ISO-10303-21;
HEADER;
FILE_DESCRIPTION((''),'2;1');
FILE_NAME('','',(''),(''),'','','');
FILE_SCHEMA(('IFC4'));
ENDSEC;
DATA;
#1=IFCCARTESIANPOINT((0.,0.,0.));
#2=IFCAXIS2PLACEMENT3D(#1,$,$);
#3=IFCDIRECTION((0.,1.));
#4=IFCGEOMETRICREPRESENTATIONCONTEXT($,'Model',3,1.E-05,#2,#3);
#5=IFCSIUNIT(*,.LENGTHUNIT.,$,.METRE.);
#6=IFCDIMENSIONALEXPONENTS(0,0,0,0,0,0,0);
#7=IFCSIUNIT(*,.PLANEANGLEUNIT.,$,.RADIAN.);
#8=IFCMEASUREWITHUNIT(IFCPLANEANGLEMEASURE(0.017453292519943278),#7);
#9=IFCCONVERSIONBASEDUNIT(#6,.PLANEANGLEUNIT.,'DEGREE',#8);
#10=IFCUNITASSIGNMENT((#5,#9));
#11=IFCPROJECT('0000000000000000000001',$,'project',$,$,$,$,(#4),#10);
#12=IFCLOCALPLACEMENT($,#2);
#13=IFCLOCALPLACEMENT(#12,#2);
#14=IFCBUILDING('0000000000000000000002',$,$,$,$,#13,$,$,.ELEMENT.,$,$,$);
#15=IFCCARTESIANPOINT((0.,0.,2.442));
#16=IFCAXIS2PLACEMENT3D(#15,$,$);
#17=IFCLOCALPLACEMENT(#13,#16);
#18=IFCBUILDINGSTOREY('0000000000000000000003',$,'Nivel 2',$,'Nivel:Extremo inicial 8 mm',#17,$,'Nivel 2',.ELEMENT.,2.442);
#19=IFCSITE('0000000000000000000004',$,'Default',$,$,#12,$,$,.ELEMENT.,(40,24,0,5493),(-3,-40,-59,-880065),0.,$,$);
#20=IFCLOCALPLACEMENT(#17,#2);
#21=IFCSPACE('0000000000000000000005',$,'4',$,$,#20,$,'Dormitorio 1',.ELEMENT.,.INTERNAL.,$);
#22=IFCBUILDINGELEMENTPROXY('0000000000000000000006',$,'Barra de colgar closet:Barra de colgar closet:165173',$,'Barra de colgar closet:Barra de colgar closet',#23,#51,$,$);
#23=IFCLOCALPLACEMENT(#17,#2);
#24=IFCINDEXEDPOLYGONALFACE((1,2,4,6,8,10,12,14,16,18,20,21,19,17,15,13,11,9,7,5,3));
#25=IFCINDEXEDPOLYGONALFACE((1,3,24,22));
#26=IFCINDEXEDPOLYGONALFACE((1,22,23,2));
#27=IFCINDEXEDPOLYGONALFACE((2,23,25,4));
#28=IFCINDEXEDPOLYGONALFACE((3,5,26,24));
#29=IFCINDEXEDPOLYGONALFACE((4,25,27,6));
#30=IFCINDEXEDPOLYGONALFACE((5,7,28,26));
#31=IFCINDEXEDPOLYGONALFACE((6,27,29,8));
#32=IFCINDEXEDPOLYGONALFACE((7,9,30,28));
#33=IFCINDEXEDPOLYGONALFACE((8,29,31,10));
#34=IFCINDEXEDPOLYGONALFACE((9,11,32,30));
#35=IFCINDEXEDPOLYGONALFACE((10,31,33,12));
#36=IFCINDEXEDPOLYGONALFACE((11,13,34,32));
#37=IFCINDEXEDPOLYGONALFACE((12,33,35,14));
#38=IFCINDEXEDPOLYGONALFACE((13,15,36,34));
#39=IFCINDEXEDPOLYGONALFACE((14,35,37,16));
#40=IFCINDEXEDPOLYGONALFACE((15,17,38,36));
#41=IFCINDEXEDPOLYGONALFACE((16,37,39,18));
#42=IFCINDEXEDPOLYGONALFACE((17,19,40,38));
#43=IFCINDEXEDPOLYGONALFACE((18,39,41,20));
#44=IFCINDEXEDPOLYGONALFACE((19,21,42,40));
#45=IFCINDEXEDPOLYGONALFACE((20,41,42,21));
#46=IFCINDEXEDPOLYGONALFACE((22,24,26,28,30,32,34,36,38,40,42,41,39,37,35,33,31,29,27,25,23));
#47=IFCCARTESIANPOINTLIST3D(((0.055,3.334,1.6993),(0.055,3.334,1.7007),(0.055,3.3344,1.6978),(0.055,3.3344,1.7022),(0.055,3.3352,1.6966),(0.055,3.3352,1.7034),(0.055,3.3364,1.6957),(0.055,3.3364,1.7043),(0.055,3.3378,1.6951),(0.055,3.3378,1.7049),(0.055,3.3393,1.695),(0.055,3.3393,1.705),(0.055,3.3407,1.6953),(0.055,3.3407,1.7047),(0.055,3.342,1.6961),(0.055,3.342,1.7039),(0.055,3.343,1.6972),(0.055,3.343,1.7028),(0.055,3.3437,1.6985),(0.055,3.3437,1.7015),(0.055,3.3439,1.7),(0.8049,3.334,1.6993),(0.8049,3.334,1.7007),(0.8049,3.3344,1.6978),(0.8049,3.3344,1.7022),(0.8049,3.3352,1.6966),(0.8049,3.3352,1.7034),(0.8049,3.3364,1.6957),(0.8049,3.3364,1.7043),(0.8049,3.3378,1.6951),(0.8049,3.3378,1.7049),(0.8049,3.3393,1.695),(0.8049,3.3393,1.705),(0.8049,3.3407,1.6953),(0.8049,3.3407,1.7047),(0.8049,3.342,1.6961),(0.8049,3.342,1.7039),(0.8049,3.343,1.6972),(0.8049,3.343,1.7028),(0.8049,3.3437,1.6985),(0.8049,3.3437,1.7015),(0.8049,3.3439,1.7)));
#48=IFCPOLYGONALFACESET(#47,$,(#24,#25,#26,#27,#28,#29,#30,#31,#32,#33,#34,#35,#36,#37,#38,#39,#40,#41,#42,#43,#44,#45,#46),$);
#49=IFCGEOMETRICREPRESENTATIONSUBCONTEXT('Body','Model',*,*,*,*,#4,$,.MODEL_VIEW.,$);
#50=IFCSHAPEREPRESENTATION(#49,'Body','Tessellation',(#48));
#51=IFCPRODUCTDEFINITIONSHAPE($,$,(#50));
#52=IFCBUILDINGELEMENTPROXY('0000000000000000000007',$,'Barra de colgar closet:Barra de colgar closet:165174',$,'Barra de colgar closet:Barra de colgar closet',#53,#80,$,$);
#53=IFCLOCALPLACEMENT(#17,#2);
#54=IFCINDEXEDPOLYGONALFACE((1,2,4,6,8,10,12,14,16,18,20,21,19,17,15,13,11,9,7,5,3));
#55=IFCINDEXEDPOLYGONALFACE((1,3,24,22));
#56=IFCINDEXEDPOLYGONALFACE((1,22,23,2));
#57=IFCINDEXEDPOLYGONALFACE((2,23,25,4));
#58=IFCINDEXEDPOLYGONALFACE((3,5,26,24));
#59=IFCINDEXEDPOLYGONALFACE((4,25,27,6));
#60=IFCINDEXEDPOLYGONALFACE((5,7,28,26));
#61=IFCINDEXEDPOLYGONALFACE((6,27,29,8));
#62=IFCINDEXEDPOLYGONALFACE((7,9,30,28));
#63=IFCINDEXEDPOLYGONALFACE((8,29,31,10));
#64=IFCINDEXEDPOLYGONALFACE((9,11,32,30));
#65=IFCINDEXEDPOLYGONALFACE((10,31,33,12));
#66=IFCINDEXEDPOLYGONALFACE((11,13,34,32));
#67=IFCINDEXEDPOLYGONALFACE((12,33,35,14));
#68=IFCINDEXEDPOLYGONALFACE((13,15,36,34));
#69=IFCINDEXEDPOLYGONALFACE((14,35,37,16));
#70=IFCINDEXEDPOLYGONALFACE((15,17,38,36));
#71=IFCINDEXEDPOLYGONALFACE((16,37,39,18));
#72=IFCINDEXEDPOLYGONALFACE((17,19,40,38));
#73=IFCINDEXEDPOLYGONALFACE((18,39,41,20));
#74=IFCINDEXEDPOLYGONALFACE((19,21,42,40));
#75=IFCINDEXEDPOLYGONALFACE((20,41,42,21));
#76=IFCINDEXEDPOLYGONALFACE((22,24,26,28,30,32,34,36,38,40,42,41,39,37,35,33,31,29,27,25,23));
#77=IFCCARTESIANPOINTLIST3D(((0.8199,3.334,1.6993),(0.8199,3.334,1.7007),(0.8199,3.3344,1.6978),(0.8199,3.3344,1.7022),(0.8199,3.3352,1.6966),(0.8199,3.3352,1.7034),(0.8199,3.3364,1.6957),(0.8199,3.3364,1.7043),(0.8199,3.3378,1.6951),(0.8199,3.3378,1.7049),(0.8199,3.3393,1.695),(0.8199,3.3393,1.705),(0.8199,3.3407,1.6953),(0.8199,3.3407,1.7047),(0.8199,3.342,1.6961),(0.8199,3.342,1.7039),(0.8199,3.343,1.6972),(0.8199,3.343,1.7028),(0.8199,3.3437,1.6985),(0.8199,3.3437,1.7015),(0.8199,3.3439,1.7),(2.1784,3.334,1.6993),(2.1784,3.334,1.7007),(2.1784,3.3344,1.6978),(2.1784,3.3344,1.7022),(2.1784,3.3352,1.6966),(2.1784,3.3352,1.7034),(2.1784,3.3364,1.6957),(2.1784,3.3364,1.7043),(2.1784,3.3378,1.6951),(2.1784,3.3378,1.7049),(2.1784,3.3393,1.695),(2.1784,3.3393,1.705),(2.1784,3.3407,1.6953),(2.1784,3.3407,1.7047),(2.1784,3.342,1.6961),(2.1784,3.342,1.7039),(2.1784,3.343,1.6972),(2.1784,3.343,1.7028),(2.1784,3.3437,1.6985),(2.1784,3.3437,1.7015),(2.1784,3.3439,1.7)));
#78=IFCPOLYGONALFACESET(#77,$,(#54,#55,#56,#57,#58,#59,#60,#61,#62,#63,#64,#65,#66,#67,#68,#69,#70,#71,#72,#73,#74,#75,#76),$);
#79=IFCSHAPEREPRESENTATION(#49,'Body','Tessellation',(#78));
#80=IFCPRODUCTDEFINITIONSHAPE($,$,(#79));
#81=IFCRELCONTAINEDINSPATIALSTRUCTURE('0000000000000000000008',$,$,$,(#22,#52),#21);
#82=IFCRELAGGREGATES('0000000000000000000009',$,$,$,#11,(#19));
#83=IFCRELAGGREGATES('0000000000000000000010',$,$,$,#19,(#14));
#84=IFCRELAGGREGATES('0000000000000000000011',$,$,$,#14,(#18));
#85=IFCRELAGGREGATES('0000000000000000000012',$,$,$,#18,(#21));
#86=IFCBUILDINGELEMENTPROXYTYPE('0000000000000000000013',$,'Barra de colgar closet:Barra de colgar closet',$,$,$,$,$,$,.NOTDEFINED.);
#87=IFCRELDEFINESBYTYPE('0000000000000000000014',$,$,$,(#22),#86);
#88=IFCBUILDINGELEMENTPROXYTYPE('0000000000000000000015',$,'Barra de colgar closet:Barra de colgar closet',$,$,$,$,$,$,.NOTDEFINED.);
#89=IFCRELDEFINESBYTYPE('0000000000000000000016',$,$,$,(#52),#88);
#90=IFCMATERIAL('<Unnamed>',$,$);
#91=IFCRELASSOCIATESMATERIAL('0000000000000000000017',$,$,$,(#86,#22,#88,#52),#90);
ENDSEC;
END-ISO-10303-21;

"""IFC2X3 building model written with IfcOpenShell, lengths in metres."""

from ifc_helpers import new_model, entity, si_unit, converted_unit, direction, frame, frame_2d, origin, place, context, subcontext, project, spatial, circle, extrude, source, transform, mapped, material, type_object, type_shapes, element, save


model = new_model("IFC2X3")

# Units and contexts
model_context = context("Model", 3, precision=1e-05, world=origin(), true_north=direction((0.0, 1.0)))
body_context = subcontext(model_context, "Body", "Model", "MODEL_VIEW")
ifc_project = project(units=[si_unit("LENGTHUNIT", "METRE"), converted_unit("PLANEANGLEUNIT", "DEGREE", entity("IfcPlaneAngleMeasure", 0.017453292519943278), si_unit("PLANEANGLEUNIT", "RADIAN"), dimensions=[0, 0, 0, 0, 0, 0, 0])], contexts=[model_context])

# Site, building, storey
site_placement = place(None, origin())
site = spatial("IfcSite", under=ifc_project, at=site_placement, Name="Default", CompositionType="ELEMENT", RefLatitude=(40, 24, 0, 5493), RefLongitude=(-3, -40, -59, -880065), RefElevation=0.0)
building_placement = place(site_placement, origin())
building = spatial("IfcBuilding", under=site, at=building_placement, CompositionType="ELEMENT")
storey_placement = place(building_placement, frame((0.0, 0.0, 2.442)))
storey = spatial("IfcBuildingStorey", under=building, at=storey_placement, Name="Nivel 2", ObjectType="Nivel:Extremo inicial 8 mm", LongName="Nivel 2", CompositionType="ELEMENT", Elevation=2.442)

# Shared definitions
ifc_material_1 = material(Name="<Unnamed>")

# Shared definitions
space_1_placement = place(storey_placement, origin())
space_1 = spatial("IfcSpace", under=storey, at=space_1_placement, Name="4", LongName="Dormitorio 1", CompositionType="ELEMENT", InteriorOrExteriorSpace="INTERNAL")

# Building element proxies
building_element_proxy_type_1 = type_object("IfcBuildingElementProxyType", Name="Barra de colgar closet:Barra de colgar closet", PredefinedType="NOTDEFINED", material=ifc_material_1)
shared_shape_1 = source(origin(), body_context, "Body", "SweptSolid", [
    extrude(circle(Radius=0.005, at=frame_2d((0.0, 0.0), x_axis=(1.0, 0.0))), frame((-0.375, 0.0, 0.0), z_axis=(1.0, 0.0, 0.0), x_axis=(0.0, 1.0, 0.0)), (0.0, 0.0, 1.0), 0.75),
])
type_shapes(building_element_proxy_type_1, [shared_shape_1])
proxy_1_placement = place(space_1_placement, frame((0.43, 3.3389, 1.7)))
element("IfcBuildingElementProxy", 1, at=proxy_1_placement, inside=space_1, type_object=building_element_proxy_type_1, material=ifc_material_1, Name="Barra de colgar closet:Barra de colgar closet:165173", ObjectType="Barra de colgar closet:Barra de colgar closet", context=body_context, shape_type="MappedRepresentation", body=[
    mapped(shared_shape_1, transform((0.0, 0.0, 0.0), scale=1.0)),
])
building_element_proxy_type_2 = type_object("IfcBuildingElementProxyType", Name="Barra de colgar closet:Barra de colgar closet", PredefinedType="NOTDEFINED", material=ifc_material_1)
shared_shape_2 = source(origin(), body_context, "Body", "SweptSolid", [
    extrude(circle(Radius=0.005, at=frame_2d((0.0, 0.0), x_axis=(1.0, 0.0))), frame((-0.6792, 0.0, 0.0), z_axis=(1.0, 0.0, 0.0), x_axis=(0.0, -1.0, 0.0)), (0.0, 0.0, 1.0), 1.3585),
])
type_shapes(building_element_proxy_type_2, [shared_shape_2])
proxy_2_placement = place(space_1_placement, frame((1.4992, 3.3389, 1.7), z_axis=(0.0, 0.0, 1.0), x_axis=(-1.0, 0.0, 0.0)))
element("IfcBuildingElementProxy", 2, at=proxy_2_placement, inside=space_1, type_object=building_element_proxy_type_2, material=ifc_material_1, Name="Barra de colgar closet:Barra de colgar closet:165174", ObjectType="Barra de colgar closet:Barra de colgar closet", context=body_context, shape_type="MappedRepresentation", body=[
    mapped(shared_shape_2, transform((0.0, 0.0, 0.0), scale=1.0)),
])

save(model, "model.ifc")
